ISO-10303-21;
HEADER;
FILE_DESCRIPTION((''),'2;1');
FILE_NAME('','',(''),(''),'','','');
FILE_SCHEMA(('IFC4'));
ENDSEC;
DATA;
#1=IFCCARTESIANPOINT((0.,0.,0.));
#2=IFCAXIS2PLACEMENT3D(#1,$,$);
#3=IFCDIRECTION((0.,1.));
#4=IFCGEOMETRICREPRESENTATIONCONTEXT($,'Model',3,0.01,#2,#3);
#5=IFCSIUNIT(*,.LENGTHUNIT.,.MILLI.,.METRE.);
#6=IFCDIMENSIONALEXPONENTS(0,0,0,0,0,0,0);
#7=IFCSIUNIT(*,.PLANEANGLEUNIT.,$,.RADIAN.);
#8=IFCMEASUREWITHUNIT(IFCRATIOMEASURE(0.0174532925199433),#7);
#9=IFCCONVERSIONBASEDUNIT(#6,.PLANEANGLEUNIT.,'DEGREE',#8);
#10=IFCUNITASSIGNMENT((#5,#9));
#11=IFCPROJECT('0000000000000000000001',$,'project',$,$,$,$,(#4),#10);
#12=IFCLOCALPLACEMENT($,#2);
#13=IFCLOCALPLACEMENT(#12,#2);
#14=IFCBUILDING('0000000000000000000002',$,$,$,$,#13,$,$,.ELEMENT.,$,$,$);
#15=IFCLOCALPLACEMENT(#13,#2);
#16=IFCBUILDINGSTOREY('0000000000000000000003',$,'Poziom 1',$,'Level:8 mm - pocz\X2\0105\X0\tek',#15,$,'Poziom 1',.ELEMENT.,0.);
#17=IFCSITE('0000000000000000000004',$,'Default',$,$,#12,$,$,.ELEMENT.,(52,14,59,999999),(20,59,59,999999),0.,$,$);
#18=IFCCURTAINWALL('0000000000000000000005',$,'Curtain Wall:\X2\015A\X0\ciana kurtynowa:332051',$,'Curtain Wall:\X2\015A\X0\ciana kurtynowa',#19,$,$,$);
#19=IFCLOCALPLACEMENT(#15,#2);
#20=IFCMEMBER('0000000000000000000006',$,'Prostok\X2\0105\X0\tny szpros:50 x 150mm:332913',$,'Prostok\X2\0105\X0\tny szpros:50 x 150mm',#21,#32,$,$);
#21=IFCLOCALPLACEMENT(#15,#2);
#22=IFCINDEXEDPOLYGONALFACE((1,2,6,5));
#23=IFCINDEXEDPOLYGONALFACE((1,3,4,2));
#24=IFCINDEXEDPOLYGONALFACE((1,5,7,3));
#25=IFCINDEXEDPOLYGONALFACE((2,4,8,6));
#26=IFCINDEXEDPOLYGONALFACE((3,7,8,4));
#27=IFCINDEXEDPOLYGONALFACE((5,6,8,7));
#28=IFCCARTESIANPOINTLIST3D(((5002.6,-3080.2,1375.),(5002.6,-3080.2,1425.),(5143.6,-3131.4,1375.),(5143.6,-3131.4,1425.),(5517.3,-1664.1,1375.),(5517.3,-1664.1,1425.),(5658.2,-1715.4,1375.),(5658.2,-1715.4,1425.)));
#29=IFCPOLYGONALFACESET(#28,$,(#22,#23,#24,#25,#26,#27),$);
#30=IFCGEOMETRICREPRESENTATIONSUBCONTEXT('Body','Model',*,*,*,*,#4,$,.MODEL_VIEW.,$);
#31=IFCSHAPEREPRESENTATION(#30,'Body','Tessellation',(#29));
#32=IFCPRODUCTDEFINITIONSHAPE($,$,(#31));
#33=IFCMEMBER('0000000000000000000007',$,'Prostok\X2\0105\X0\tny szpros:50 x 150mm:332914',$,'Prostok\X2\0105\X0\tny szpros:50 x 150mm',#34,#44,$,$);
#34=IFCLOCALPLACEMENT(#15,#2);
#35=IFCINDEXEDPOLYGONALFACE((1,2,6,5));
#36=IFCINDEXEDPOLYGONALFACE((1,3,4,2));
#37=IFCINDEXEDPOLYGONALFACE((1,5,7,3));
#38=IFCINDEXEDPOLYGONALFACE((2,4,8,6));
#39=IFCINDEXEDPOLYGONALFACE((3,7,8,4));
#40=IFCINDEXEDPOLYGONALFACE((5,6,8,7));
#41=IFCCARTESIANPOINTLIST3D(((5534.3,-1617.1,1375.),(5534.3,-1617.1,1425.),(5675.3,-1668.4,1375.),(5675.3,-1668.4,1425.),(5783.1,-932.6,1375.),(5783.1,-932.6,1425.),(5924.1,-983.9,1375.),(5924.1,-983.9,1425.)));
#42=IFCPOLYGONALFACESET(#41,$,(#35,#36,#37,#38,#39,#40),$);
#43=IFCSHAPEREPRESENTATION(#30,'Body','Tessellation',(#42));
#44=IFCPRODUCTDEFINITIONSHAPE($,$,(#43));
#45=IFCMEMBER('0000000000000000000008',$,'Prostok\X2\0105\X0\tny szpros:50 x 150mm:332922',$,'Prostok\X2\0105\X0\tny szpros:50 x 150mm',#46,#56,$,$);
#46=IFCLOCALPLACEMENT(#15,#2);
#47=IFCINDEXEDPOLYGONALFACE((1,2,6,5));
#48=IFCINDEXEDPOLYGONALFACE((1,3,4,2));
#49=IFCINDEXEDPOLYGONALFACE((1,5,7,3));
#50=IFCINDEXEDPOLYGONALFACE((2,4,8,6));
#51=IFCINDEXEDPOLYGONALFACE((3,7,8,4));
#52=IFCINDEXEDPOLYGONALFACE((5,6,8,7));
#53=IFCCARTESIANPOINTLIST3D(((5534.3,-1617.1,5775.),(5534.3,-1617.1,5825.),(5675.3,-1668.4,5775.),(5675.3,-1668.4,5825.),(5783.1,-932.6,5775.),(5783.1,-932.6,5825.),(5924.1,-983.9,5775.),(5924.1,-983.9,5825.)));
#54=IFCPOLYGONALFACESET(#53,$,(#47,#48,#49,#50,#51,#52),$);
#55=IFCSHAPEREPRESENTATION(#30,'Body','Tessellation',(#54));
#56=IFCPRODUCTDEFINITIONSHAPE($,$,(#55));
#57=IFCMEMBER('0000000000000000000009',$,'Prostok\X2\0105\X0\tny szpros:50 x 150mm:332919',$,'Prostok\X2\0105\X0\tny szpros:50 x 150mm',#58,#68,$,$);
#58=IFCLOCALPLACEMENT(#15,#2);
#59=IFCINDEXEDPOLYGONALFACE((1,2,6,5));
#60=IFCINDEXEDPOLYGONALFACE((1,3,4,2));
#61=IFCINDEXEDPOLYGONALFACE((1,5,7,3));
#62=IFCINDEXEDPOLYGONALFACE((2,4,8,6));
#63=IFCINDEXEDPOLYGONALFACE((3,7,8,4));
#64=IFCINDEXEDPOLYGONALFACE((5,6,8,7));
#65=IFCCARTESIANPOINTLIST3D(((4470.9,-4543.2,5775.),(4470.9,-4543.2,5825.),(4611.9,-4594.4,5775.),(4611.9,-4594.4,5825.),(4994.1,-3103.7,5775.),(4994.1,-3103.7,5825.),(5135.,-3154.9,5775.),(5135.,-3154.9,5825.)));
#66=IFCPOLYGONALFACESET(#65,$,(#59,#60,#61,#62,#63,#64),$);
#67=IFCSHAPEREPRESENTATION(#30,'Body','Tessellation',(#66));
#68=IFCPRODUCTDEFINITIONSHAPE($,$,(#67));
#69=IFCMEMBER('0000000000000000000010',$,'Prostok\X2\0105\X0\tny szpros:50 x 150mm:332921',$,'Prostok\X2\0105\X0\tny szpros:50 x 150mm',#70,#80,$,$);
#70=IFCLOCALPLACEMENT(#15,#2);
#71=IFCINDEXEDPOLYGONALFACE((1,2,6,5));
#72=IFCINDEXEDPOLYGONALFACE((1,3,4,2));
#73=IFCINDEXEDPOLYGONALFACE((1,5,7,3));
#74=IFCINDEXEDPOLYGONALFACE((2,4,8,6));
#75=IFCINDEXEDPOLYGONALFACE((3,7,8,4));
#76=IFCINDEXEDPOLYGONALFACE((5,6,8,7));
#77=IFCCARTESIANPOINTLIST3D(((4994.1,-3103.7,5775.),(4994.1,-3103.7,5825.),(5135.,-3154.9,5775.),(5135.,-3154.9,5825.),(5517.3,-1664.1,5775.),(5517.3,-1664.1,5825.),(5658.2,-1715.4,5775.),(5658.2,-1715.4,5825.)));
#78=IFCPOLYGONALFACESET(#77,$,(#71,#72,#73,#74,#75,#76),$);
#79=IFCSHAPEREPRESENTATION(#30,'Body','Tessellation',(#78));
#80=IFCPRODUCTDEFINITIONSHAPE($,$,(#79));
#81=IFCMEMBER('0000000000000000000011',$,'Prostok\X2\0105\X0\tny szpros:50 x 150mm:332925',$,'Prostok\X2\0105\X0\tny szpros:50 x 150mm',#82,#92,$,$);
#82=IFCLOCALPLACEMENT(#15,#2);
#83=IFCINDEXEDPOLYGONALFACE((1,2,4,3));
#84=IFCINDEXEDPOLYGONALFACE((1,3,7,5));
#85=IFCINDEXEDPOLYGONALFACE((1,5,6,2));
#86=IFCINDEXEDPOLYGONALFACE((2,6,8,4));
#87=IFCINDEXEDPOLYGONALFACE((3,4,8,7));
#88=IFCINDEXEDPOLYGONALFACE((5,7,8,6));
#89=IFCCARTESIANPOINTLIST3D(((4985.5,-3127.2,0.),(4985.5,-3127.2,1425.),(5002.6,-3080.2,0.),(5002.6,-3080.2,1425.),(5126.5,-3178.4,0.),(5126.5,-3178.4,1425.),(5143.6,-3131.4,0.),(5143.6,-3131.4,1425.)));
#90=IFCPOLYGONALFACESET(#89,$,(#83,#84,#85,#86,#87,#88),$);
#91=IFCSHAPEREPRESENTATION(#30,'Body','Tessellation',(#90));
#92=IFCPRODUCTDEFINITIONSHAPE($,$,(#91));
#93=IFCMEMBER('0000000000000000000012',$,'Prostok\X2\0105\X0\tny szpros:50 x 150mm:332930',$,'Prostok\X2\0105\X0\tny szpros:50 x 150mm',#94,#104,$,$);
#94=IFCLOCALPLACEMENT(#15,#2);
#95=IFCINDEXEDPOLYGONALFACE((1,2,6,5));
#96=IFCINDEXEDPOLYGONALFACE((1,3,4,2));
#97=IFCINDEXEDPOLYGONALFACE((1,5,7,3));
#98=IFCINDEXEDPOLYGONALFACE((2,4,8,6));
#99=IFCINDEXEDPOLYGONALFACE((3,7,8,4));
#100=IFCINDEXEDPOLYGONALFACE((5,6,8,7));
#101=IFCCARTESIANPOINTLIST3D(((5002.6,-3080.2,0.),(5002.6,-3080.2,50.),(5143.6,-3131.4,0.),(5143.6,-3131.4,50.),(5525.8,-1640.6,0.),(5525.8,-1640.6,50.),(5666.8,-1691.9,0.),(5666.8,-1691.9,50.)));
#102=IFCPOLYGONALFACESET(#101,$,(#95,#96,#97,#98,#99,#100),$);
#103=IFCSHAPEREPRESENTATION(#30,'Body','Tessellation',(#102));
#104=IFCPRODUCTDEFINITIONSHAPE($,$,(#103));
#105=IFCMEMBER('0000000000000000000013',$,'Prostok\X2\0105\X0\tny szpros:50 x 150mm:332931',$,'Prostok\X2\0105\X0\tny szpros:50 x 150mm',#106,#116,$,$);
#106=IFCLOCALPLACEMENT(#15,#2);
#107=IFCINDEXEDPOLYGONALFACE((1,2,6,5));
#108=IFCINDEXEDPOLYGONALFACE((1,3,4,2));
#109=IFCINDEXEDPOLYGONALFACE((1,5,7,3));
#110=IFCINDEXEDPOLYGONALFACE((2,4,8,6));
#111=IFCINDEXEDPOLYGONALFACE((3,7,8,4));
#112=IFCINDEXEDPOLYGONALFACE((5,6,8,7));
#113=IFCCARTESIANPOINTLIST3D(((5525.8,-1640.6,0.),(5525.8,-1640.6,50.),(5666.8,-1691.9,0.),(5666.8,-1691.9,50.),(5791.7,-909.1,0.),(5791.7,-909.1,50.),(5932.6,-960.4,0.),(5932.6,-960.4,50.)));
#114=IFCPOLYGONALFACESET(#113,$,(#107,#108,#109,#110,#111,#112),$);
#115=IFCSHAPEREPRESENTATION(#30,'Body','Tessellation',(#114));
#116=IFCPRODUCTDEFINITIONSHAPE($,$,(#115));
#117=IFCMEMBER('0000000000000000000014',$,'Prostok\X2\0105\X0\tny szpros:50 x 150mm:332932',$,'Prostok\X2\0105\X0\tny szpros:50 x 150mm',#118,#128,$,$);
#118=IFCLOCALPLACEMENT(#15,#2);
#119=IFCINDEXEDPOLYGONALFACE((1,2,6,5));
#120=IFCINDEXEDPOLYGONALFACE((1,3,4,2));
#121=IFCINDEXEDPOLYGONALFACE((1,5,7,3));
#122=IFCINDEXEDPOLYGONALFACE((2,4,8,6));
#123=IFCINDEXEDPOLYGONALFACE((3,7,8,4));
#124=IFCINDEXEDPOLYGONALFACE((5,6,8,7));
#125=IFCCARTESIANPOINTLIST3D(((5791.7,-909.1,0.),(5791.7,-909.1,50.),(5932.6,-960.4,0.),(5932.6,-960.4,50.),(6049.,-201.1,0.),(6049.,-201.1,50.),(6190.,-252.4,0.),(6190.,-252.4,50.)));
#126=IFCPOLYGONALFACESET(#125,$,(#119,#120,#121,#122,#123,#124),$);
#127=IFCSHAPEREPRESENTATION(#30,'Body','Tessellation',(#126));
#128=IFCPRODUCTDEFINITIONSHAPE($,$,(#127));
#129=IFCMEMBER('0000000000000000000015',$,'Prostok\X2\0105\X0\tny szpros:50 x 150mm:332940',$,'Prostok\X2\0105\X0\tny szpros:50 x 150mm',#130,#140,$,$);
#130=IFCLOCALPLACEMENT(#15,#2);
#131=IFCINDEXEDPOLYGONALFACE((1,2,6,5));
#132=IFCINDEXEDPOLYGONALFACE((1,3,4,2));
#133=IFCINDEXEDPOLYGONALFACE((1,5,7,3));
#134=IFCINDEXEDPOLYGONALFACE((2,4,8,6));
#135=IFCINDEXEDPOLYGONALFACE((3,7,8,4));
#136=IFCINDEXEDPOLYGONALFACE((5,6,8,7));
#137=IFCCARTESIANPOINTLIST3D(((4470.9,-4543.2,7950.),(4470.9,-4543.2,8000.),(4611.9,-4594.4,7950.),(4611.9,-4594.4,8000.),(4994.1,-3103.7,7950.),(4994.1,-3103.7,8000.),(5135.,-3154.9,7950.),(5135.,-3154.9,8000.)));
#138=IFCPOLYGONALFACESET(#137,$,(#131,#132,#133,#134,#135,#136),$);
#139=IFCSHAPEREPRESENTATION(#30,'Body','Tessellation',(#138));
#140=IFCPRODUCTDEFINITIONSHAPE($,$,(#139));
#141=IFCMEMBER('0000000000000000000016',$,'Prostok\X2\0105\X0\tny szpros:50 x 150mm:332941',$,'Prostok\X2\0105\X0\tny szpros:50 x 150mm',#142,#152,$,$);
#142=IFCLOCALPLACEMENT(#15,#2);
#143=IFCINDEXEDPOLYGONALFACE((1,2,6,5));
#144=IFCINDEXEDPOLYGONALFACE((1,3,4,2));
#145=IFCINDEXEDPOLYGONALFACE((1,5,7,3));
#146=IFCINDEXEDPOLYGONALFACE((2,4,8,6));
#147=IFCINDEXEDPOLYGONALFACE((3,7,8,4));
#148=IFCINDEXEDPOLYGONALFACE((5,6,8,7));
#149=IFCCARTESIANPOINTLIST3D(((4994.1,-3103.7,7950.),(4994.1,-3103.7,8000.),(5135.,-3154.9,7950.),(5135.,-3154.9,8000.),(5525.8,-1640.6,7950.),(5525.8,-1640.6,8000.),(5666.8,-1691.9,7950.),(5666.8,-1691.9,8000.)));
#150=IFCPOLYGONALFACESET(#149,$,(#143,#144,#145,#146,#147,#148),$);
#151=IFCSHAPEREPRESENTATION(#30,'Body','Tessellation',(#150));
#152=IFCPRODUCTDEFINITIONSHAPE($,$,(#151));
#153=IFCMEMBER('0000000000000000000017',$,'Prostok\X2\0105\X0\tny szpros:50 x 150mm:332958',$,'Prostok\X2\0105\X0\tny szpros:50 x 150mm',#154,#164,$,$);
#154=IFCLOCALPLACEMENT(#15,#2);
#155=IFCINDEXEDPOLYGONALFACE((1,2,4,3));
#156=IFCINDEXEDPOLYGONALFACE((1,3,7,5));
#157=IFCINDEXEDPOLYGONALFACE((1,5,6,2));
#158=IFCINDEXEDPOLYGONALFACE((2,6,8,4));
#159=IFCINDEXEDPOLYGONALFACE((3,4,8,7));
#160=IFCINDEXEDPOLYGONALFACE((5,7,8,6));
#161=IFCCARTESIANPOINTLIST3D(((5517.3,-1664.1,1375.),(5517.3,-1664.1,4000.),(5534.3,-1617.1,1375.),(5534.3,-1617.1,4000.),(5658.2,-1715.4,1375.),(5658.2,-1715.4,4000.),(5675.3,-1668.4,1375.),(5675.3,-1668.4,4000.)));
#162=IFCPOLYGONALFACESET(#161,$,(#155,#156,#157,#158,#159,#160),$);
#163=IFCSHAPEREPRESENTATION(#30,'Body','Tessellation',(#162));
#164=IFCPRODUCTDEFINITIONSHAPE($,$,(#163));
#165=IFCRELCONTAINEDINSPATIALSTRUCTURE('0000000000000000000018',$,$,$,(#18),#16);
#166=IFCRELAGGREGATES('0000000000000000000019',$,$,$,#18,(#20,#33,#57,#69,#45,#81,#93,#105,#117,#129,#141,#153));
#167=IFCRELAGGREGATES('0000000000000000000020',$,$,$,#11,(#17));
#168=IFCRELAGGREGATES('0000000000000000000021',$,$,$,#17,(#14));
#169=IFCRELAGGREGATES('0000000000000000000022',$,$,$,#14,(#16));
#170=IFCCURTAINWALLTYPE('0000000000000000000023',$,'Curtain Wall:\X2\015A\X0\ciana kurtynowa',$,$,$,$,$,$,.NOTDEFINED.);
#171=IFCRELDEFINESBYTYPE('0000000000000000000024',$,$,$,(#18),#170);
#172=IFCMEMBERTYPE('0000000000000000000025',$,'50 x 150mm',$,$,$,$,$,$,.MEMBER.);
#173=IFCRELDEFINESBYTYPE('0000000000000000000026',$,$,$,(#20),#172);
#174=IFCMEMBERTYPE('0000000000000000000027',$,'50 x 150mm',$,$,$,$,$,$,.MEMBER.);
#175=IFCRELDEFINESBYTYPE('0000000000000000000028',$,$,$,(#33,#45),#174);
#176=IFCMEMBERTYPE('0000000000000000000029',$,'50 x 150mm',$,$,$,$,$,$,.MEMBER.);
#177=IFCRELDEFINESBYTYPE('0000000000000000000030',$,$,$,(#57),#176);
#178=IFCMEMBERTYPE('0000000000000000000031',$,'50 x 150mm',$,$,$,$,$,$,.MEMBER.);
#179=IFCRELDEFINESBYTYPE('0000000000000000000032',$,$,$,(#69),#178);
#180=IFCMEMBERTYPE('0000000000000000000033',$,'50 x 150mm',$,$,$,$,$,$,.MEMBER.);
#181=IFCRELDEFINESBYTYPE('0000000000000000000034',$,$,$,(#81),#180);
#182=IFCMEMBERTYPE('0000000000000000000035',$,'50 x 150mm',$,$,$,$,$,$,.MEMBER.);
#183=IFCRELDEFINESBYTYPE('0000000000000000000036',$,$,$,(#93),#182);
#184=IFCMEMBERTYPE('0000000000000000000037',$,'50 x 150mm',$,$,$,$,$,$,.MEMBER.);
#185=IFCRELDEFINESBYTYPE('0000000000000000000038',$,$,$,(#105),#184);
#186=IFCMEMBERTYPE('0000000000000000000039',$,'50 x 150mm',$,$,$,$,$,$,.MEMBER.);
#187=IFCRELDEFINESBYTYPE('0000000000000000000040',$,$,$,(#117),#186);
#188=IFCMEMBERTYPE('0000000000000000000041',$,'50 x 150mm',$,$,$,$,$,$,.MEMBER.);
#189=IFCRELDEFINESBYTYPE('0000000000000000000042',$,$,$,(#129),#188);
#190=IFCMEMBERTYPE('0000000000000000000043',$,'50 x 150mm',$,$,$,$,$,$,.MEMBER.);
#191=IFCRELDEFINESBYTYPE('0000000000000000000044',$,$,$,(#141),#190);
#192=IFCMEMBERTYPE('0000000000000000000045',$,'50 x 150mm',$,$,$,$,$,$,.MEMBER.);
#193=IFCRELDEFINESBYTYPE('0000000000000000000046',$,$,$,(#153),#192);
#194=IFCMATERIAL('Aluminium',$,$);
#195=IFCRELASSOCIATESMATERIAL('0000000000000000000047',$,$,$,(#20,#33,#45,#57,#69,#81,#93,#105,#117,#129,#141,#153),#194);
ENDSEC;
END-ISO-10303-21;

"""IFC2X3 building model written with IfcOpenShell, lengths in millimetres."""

from ifc_helpers import new_model, entity, si_unit, converted_unit, direction, frame, origin, origin_2d_with_axis, place, context, subcontext, project, spatial, rectangle, extrude, source, transform, mapped, material, type_object, type_shapes, element, aggregate, save


model = new_model("IFC2X3")

# Units and contexts
model_context = context("Model", 3, precision=0.01, world=origin(), true_north=direction((0.0, 1.0)))
body_context = subcontext(model_context, "Body", "Model", "MODEL_VIEW")
ifc_project = project(units=[si_unit("LENGTHUNIT", "METRE", prefix="MILLI"), converted_unit("PLANEANGLEUNIT", "DEGREE", entity("IfcRatioMeasure", 0.0174532925199433), si_unit("PLANEANGLEUNIT", "RADIAN"), dimensions=[0, 0, 0, 0, 0, 0, 0])], contexts=[model_context])

# Site, building, storey
site_placement = place(None, origin())
site = spatial("IfcSite", under=ifc_project, at=site_placement, Name="Default", CompositionType="ELEMENT", RefLatitude=(52, 14, 59, 999999), RefLongitude=(20, 59, 59, 999999), RefElevation=0.0)
building_placement = place(site_placement, origin())
building = spatial("IfcBuilding", under=site, at=building_placement, CompositionType="ELEMENT")
storey_placement = place(building_placement, origin())
storey = spatial("IfcBuildingStorey", under=building, at=storey_placement, Name="Poziom 1", ObjectType="Level:8 mm - początek", LongName="Poziom 1", CompositionType="ELEMENT", Elevation=0.0)

# Curtain wall, members
curtain_wall_type = type_object("IfcCurtainWallType", Name="Curtain Wall:Ściana kurtynowa", PredefinedType="NOTDEFINED")
curtain_wall_placement = place(storey_placement, origin())
curtain_wall = element("IfcCurtainWall", 1, at=curtain_wall_placement, inside=storey, type_object=curtain_wall_type, Name="Curtain Wall:Ściana kurtynowa:332051", ObjectType="Curtain Wall:Ściana kurtynowa")
ifc_material_1 = material(Name="Aluminium")
member_type_1 = type_object("IfcMemberType", Name="50 x 150mm", PredefinedType="MEMBER")
shared_shape_1 = source(origin(), body_context, "Body", "SweptSolid", [
    extrude(rectangle(XDim=150.0, YDim=50.0, at=origin_2d_with_axis()), frame((0.0, 0.0, -1506.6), z_axis=(0.0, 0.0, 1.0), x_axis=(0.0, -1.0, 0.0)), (0.0, 0.0, 1.0), 1506.6),
])
type_shapes(member_type_1, [shared_shape_1])
member_1_placement = place(storey_placement, frame((5587.7, -1689.8, 1400.0), z_axis=(0.341586, 0.939851, 0.0), x_axis=(0.0, 0.0, 1.0)))
member_1 = element("IfcMember", 2, at=member_1_placement, type_object=member_type_1, material=ifc_material_1, Name="Prostokątny szpros:50 x 150mm:332913", ObjectType="Prostokątny szpros:50 x 150mm", context=body_context, shape_type="MappedRepresentation", body=[
    mapped(shared_shape_1, transform((0.0, 0.0, 0.0), scale=1.0)),
])
member_type_2 = type_object("IfcMemberType", Name="50 x 150mm", PredefinedType="MEMBER")
shared_shape_2 = source(origin(), body_context, "Body", "SweptSolid", [
    extrude(rectangle(XDim=150.0, YDim=50.0, at=origin_2d_with_axis()), frame((0.0, 0.0, -728.3), z_axis=(0.0, 0.0, 1.0), x_axis=(0.0, -1.0, 0.0)), (0.0, 0.0, 1.0), 728.3),
])
type_shapes(member_type_2, [shared_shape_2])
member_2_placement = place(storey_placement, frame((5853.6, -958.2, 1400.0), z_axis=(0.341586, 0.939851, 0.0), x_axis=(0.0, 0.0, 1.0)))
member_2 = element("IfcMember", 3, at=member_2_placement, type_object=member_type_2, material=ifc_material_1, Name="Prostokątny szpros:50 x 150mm:332914", ObjectType="Prostokątny szpros:50 x 150mm", context=body_context, shape_type="MappedRepresentation", body=[
    mapped(shared_shape_2, transform((0.0, 0.0, 0.0), scale=1.0)),
])
member_3_placement = place(storey_placement, frame((5853.6, -958.2, 5800.0), z_axis=(0.341586, 0.939851, 0.0), x_axis=(0.0, 0.0, 1.0)))
member_3 = element("IfcMember", 4, at=member_3_placement, type_object=member_type_2, material=ifc_material_1, Name="Prostokątny szpros:50 x 150mm:332922", ObjectType="Prostokątny szpros:50 x 150mm", context=body_context, shape_type="MappedRepresentation", body=[
    mapped(shared_shape_2, transform((0.0, 0.0, 0.0), scale=1.0)),
])
member_type_3 = type_object("IfcMemberType", Name="50 x 150mm", PredefinedType="MEMBER")
shared_shape_3 = source(origin(), body_context, "Body", "SweptSolid", [
    extrude(rectangle(XDim=150.0, YDim=50.0, at=origin_2d_with_axis()), frame((0.0, 0.0, -1531.6), z_axis=(0.0, 0.0, 1.0), x_axis=(0.0, -1.0, 0.0)), (0.0, 0.0, 1.0), 1531.6),
])
type_shapes(member_type_3, [shared_shape_3])
member_4_placement = place(storey_placement, frame((5064.6, -3129.3, 5800.0), z_axis=(0.341586, 0.939851, 0.0), x_axis=(0.0, 0.0, 1.0)))
member_4 = element("IfcMember", 5, at=member_4_placement, type_object=member_type_3, material=ifc_material_1, Name="Prostokątny szpros:50 x 150mm:332919", ObjectType="Prostokątny szpros:50 x 150mm", context=body_context, shape_type="MappedRepresentation", body=[
    mapped(shared_shape_3, transform((0.0, 0.0, 0.0), scale=1.0)),
])
member_type_4 = type_object("IfcMemberType", Name="50 x 150mm", PredefinedType="MEMBER")
shared_shape_4 = source(origin(), body_context, "Body", "SweptSolid", [
    extrude(rectangle(XDim=150.0, YDim=50.0, at=origin_2d_with_axis()), frame((0.0, 0.0, -1531.6), z_axis=(0.0, 0.0, 1.0), x_axis=(0.0, -1.0, 0.0)), (0.0, 0.0, 1.0), 1531.6),
])
type_shapes(member_type_4, [shared_shape_4])
member_5_placement = place(storey_placement, frame((5587.7, -1689.8, 5800.0), z_axis=(0.341586, 0.939851, 0.0), x_axis=(0.0, 0.0, 1.0)))
member_5 = element("IfcMember", 6, at=member_5_placement, type_object=member_type_4, material=ifc_material_1, Name="Prostokątny szpros:50 x 150mm:332921", ObjectType="Prostokątny szpros:50 x 150mm", context=body_context, shape_type="MappedRepresentation", body=[
    mapped(shared_shape_4, transform((0.0, 0.0, 0.0), scale=1.0)),
])
member_type_5 = type_object("IfcMemberType", Name="50 x 150mm", PredefinedType="MEMBER")
shared_shape_5 = source(origin(), body_context, "Body", "SweptSolid", [
    extrude(rectangle(XDim=150.0, YDim=50.0, at=origin_2d_with_axis()), frame((0.0, 0.0, -1425.0), z_axis=(0.0, 0.0, 1.0), x_axis=(0.0, -1.0, 0.0)), (0.0, 0.0, 1.0), 1425.0),
])
type_shapes(member_type_5, [shared_shape_5])
member_6_placement = place(storey_placement, frame((5064.6, -3129.3, 0.0), z_axis=(0.0, 0.0, -1.0), x_axis=(0.341586, 0.939851, 0.0)))
member_6 = element("IfcMember", 7, at=member_6_placement, type_object=member_type_5, material=ifc_material_1, Name="Prostokątny szpros:50 x 150mm:332925", ObjectType="Prostokątny szpros:50 x 150mm", context=body_context, shape_type="MappedRepresentation", body=[
    mapped(shared_shape_5, transform((0.0, 0.0, 0.0), scale=1.0)),
])
member_type_6 = type_object("IfcMemberType", Name="50 x 150mm", PredefinedType="MEMBER")
shared_shape_6 = source(origin(), body_context, "Body", "SweptSolid", [
    extrude(rectangle(XDim=150.0, YDim=50.0, at=origin_2d_with_axis()), frame((-25.0, 0.0, -1531.6), z_axis=(0.0, 0.0, 1.0), x_axis=(0.0, -1.0, 0.0)), (0.0, 0.0, 1.0), 1531.6),
])
type_shapes(member_type_6, [shared_shape_6])
member_7_placement = place(storey_placement, frame((5073.1, -3105.8, 0.0), z_axis=(-0.341586, -0.939851, 0.0), x_axis=(0.0, 0.0, -1.0)))
member_7 = element("IfcMember", 8, at=member_7_placement, type_object=member_type_6, material=ifc_material_1, Name="Prostokątny szpros:50 x 150mm:332930", ObjectType="Prostokątny szpros:50 x 150mm", context=body_context, shape_type="MappedRepresentation", body=[
    mapped(shared_shape_6, transform((0.0, 0.0, 0.0), scale=1.0)),
])
member_type_7 = type_object("IfcMemberType", Name="50 x 150mm", PredefinedType="MEMBER")
shared_shape_7 = source(origin(), body_context, "Body", "SweptSolid", [
    extrude(rectangle(XDim=150.0, YDim=50.0, at=origin_2d_with_axis()), frame((-25.0, 0.0, -778.3), z_axis=(0.0, 0.0, 1.0), x_axis=(0.0, -1.0, 0.0)), (0.0, 0.0, 1.0), 778.3),
])
type_shapes(member_type_7, [shared_shape_7])
member_8_placement = place(storey_placement, frame((5596.3, -1666.3, 0.0), z_axis=(-0.341586, -0.939851, 0.0), x_axis=(0.0, 0.0, -1.0)))
member_8 = element("IfcMember", 9, at=member_8_placement, type_object=member_type_7, material=ifc_material_1, Name="Prostokątny szpros:50 x 150mm:332931", ObjectType="Prostokątny szpros:50 x 150mm", context=body_context, shape_type="MappedRepresentation", body=[
    mapped(shared_shape_7, transform((0.0, 0.0, 0.0), scale=1.0)),
])
member_type_8 = type_object("IfcMemberType", Name="50 x 150mm", PredefinedType="MEMBER")
shared_shape_8 = source(origin(), body_context, "Body", "SweptSolid", [
    extrude(rectangle(XDim=150.0, YDim=50.0, at=origin_2d_with_axis()), frame((-25.0, 0.0, -753.3), z_axis=(0.0, 0.0, 1.0), x_axis=(0.0, -1.0, 0.0)), (0.0, 0.0, 1.0), 753.3),
])
type_shapes(member_type_8, [shared_shape_8])
member_9_placement = place(storey_placement, frame((5862.1, -934.8, 0.0), z_axis=(-0.341586, -0.939851, 0.0), x_axis=(0.0, 0.0, -1.0)))
member_9 = element("IfcMember", 10, at=member_9_placement, type_object=member_type_8, material=ifc_material_1, Name="Prostokątny szpros:50 x 150mm:332932", ObjectType="Prostokątny szpros:50 x 150mm", context=body_context, shape_type="MappedRepresentation", body=[
    mapped(shared_shape_8, transform((0.0, 0.0, 0.0), scale=1.0)),
])
member_type_9 = type_object("IfcMemberType", Name="50 x 150mm", PredefinedType="MEMBER")
shared_shape_9 = source(origin(), body_context, "Body", "SweptSolid", [
    extrude(rectangle(XDim=150.0, YDim=50.0, at=origin_2d_with_axis()), frame((-25.0, 0.0, -1531.6), z_axis=(0.0, 0.0, 1.0), x_axis=(0.0, -1.0, 0.0)), (0.0, 0.0, 1.0), 1531.6),
])
type_shapes(member_type_9, [shared_shape_9])
member_10_placement = place(storey_placement, frame((5064.6, -3129.3, 8000.0), z_axis=(0.341586, 0.939851, 0.0), x_axis=(0.0, 0.0, 1.0)))
member_10 = element("IfcMember", 11, at=member_10_placement, type_object=member_type_9, material=ifc_material_1, Name="Prostokątny szpros:50 x 150mm:332940", ObjectType="Prostokątny szpros:50 x 150mm", context=body_context, shape_type="MappedRepresentation", body=[
    mapped(shared_shape_9, transform((0.0, 0.0, 0.0), scale=1.0)),
])
member_type_10 = type_object("IfcMemberType", Name="50 x 150mm", PredefinedType="MEMBER")
shared_shape_10 = source(origin(), body_context, "Body", "SweptSolid", [
    extrude(rectangle(XDim=150.0, YDim=50.0, at=origin_2d_with_axis()), frame((-25.0, 0.0, -1556.6), z_axis=(0.0, 0.0, 1.0), x_axis=(0.0, -1.0, 0.0)), (0.0, 0.0, 1.0), 1556.6),
])
type_shapes(member_type_10, [shared_shape_10])
member_11_placement = place(storey_placement, frame((5596.3, -1666.3, 8000.0), z_axis=(0.341586, 0.939851, 0.0), x_axis=(0.0, 0.0, 1.0)))
member_11 = element("IfcMember", 12, at=member_11_placement, type_object=member_type_10, material=ifc_material_1, Name="Prostokątny szpros:50 x 150mm:332941", ObjectType="Prostokątny szpros:50 x 150mm", context=body_context, shape_type="MappedRepresentation", body=[
    mapped(shared_shape_10, transform((0.0, 0.0, 0.0), scale=1.0)),
])
member_type_11 = type_object("IfcMemberType", Name="50 x 150mm", PredefinedType="MEMBER")
shared_shape_11 = source(origin(), body_context, "Body", "SweptSolid", [
    extrude(rectangle(XDim=150.0, YDim=50.0, at=origin_2d_with_axis()), frame((0.0, 0.0, -2625.0), z_axis=(0.0, 0.0, 1.0), x_axis=(0.0, -1.0, 0.0)), (0.0, 0.0, 1.0), 2625.0),
])
type_shapes(member_type_11, [shared_shape_11])
member_12_placement = place(storey_placement, frame((5596.3, -1666.3, 1375.0), z_axis=(0.0, 0.0, -1.0), x_axis=(0.341586, 0.939851, 0.0)))
member_12 = element("IfcMember", 13, at=member_12_placement, type_object=member_type_11, material=ifc_material_1, Name="Prostokątny szpros:50 x 150mm:332958", ObjectType="Prostokątny szpros:50 x 150mm", context=body_context, shape_type="MappedRepresentation", body=[
    mapped(shared_shape_11, transform((0.0, 0.0, 0.0), scale=1.0)),
])

aggregate(curtain_wall, [member_1, member_2, member_4, member_5, member_3, member_6, member_7, member_8, member_9, member_10, member_11, member_12])

save(model, "model.ifc")
